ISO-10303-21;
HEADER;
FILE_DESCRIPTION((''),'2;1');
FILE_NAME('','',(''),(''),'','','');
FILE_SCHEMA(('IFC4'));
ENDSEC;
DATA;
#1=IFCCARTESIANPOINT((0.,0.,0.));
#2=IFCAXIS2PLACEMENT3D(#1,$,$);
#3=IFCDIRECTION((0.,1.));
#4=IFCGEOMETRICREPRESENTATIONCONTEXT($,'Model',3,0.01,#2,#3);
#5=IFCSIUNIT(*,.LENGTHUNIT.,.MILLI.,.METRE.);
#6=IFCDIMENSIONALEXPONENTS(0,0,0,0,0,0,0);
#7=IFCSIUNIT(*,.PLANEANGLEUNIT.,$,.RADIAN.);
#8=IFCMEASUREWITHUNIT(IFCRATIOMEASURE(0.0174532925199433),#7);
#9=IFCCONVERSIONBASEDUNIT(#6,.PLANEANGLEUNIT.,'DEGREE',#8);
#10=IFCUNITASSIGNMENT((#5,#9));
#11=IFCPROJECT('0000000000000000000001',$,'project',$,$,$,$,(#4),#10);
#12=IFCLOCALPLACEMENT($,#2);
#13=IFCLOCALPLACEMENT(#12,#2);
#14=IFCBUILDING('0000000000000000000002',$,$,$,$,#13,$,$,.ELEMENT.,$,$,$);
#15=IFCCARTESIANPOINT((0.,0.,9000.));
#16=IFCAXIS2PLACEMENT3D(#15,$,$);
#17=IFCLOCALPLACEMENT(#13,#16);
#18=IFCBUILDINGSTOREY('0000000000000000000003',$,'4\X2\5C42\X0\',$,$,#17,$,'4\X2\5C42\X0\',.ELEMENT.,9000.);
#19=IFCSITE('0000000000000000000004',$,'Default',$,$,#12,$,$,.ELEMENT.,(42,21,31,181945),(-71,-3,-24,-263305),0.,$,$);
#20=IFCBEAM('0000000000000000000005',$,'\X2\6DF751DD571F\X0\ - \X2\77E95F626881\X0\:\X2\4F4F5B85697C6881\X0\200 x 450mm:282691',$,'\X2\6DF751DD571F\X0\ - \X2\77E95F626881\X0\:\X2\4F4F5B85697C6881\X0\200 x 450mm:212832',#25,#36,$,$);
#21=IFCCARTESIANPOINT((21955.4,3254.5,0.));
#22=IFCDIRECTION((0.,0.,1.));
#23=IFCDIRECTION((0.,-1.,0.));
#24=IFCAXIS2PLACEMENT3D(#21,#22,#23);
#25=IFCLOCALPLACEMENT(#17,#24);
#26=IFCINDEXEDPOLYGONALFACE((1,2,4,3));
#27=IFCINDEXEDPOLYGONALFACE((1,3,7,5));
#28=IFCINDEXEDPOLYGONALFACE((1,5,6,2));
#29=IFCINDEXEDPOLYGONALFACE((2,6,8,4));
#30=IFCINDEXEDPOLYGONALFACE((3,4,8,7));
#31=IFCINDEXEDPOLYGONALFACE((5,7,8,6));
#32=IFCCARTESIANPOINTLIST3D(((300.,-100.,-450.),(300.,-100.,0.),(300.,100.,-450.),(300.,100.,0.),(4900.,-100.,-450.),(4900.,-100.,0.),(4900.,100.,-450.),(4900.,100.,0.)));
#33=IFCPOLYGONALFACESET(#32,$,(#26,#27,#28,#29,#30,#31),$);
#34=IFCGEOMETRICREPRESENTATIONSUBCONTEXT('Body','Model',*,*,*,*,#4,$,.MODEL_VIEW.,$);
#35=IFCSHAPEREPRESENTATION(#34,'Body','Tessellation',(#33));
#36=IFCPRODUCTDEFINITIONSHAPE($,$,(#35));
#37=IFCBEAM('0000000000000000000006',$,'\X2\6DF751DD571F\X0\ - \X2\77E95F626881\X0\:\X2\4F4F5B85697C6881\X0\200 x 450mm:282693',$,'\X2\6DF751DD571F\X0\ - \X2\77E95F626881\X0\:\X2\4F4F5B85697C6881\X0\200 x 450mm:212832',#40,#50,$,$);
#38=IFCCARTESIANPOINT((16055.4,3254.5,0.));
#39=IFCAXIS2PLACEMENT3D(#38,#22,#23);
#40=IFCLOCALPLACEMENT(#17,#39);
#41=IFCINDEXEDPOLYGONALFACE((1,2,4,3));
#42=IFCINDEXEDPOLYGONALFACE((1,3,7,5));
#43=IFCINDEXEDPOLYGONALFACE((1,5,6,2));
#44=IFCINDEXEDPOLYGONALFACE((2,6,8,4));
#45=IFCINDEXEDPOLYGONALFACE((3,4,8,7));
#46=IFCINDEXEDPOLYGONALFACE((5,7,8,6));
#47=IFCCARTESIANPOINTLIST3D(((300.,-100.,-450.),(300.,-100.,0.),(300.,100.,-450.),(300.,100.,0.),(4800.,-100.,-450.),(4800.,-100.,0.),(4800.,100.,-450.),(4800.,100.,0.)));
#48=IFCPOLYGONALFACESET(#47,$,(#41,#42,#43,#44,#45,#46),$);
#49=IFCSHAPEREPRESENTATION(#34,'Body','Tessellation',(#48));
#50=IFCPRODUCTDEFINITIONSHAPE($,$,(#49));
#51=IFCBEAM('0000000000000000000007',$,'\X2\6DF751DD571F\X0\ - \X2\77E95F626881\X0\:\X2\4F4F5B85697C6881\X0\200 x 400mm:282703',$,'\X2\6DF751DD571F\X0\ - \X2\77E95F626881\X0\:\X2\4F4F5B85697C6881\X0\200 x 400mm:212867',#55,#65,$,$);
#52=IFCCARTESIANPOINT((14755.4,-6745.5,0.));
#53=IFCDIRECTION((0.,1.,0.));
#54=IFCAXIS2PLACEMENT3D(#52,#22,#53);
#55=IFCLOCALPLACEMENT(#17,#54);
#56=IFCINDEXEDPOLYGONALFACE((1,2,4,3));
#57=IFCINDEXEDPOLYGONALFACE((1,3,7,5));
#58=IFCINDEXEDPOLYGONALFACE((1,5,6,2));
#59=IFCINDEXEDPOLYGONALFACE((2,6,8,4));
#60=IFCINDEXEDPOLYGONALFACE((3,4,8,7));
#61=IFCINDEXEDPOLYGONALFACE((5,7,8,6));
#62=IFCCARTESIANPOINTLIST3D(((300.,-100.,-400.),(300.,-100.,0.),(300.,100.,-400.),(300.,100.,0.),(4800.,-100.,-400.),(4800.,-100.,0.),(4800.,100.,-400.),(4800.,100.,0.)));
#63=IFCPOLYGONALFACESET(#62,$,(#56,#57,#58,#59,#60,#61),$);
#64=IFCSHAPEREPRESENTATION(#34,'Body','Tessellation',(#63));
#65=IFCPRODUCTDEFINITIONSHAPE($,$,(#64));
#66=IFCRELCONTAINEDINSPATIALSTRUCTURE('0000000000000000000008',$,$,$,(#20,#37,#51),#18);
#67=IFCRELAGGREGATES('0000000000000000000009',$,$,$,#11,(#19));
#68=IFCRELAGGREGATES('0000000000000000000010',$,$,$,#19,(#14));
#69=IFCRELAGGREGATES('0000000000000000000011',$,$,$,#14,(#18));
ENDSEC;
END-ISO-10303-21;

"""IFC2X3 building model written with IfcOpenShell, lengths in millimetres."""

from ifc_helpers import new_model, entity, si_unit, converted_unit, direction, frame, frame_2d, origin, origin_2d_with_axis, place, context, subcontext, project, spatial, rectangle, extrude, element, save


model = new_model("IFC2X3")

# Units and contexts
model_context = context("Model", 3, precision=0.01, world=origin(), true_north=direction((0.0, 1.0)))
body_context = subcontext(model_context, "Body", "Model", "MODEL_VIEW")
ifc_project = project(units=[si_unit("LENGTHUNIT", "METRE", prefix="MILLI"), converted_unit("PLANEANGLEUNIT", "DEGREE", entity("IfcRatioMeasure", 0.0174532925199433), si_unit("PLANEANGLEUNIT", "RADIAN"), dimensions=[0, 0, 0, 0, 0, 0, 0])], contexts=[model_context])

# Site, building, storey
site_placement = place(None, origin())
site = spatial("IfcSite", under=ifc_project, at=site_placement, Name="Default", CompositionType="ELEMENT", RefLatitude=(42, 21, 31, 181945), RefLongitude=(-71, -3, -24, -263305), RefElevation=0.0)
building_placement = place(site_placement, origin())
building = spatial("IfcBuilding", under=site, at=building_placement, CompositionType="ELEMENT")
storey_placement = place(building_placement, frame((0.0, 0.0, 9000.0)))
storey = spatial("IfcBuildingStorey", under=building, at=storey_placement, Name="4层", LongName="4层", CompositionType="ELEMENT", Elevation=9000.0)

# Beams
beam_1_placement = place(storey_placement, frame((21955.4, 3254.5, 0.0), z_axis=(0.0, 0.0, 1.0), x_axis=(0.0, -1.0, 0.0)))
element("IfcBeam", 1, at=beam_1_placement, inside=storey, Name="混凝土 - 矩形梁:住宅楼梁200 x 450mm:282691", ObjectType="混凝土 - 矩形梁:住宅楼梁200 x 450mm:212832", context=body_context, shape_type="SweptSolid", body=[
    extrude(rectangle(XDim=450.0, YDim=200.0, at=frame_2d((0.0, 0.0), x_axis=(1.0, 0.0))), frame((300.0, 0.0, -225.0), z_axis=(1.0, 0.0, 0.0), x_axis=(0.0, 0.0, -1.0)), (0.0, 0.0, 1.0), 4600.0),
])
beam_2_placement = place(storey_placement, frame((16055.4, 3254.5, 0.0), z_axis=(0.0, 0.0, 1.0), x_axis=(0.0, -1.0, 0.0)))
element("IfcBeam", 2, at=beam_2_placement, inside=storey, Name="混凝土 - 矩形梁:住宅楼梁200 x 450mm:282693", ObjectType="混凝土 - 矩形梁:住宅楼梁200 x 450mm:212832", context=body_context, shape_type="SweptSolid", body=[
    extrude(rectangle(XDim=450.0, YDim=200.0, at=frame_2d((0.0, 0.0), x_axis=(1.0, 0.0))), frame((300.0, 0.0, -225.0), z_axis=(1.0, 0.0, 0.0), x_axis=(0.0, 0.0, -1.0)), (0.0, 0.0, 1.0), 4500.0),
])
beam_3_placement = place(storey_placement, frame((14755.4, -6745.5, 0.0), z_axis=(0.0, 0.0, 1.0), x_axis=(0.0, 1.0, 0.0)))
element("IfcBeam", 3, at=beam_3_placement, inside=storey, Name="混凝土 - 矩形梁:住宅楼梁200 x 400mm:282703", ObjectType="混凝土 - 矩形梁:住宅楼梁200 x 400mm:212867", context=body_context, shape_type="SweptSolid", body=[
    extrude(rectangle(XDim=400.0, YDim=200.0, at=origin_2d_with_axis()), frame((300.0, 0.0, -200.0), z_axis=(1.0, 0.0, 0.0), x_axis=(0.0, 0.0, -1.0)), (0.0, 0.0, 1.0), 4500.0),
])

save(model, "model.ifc")
